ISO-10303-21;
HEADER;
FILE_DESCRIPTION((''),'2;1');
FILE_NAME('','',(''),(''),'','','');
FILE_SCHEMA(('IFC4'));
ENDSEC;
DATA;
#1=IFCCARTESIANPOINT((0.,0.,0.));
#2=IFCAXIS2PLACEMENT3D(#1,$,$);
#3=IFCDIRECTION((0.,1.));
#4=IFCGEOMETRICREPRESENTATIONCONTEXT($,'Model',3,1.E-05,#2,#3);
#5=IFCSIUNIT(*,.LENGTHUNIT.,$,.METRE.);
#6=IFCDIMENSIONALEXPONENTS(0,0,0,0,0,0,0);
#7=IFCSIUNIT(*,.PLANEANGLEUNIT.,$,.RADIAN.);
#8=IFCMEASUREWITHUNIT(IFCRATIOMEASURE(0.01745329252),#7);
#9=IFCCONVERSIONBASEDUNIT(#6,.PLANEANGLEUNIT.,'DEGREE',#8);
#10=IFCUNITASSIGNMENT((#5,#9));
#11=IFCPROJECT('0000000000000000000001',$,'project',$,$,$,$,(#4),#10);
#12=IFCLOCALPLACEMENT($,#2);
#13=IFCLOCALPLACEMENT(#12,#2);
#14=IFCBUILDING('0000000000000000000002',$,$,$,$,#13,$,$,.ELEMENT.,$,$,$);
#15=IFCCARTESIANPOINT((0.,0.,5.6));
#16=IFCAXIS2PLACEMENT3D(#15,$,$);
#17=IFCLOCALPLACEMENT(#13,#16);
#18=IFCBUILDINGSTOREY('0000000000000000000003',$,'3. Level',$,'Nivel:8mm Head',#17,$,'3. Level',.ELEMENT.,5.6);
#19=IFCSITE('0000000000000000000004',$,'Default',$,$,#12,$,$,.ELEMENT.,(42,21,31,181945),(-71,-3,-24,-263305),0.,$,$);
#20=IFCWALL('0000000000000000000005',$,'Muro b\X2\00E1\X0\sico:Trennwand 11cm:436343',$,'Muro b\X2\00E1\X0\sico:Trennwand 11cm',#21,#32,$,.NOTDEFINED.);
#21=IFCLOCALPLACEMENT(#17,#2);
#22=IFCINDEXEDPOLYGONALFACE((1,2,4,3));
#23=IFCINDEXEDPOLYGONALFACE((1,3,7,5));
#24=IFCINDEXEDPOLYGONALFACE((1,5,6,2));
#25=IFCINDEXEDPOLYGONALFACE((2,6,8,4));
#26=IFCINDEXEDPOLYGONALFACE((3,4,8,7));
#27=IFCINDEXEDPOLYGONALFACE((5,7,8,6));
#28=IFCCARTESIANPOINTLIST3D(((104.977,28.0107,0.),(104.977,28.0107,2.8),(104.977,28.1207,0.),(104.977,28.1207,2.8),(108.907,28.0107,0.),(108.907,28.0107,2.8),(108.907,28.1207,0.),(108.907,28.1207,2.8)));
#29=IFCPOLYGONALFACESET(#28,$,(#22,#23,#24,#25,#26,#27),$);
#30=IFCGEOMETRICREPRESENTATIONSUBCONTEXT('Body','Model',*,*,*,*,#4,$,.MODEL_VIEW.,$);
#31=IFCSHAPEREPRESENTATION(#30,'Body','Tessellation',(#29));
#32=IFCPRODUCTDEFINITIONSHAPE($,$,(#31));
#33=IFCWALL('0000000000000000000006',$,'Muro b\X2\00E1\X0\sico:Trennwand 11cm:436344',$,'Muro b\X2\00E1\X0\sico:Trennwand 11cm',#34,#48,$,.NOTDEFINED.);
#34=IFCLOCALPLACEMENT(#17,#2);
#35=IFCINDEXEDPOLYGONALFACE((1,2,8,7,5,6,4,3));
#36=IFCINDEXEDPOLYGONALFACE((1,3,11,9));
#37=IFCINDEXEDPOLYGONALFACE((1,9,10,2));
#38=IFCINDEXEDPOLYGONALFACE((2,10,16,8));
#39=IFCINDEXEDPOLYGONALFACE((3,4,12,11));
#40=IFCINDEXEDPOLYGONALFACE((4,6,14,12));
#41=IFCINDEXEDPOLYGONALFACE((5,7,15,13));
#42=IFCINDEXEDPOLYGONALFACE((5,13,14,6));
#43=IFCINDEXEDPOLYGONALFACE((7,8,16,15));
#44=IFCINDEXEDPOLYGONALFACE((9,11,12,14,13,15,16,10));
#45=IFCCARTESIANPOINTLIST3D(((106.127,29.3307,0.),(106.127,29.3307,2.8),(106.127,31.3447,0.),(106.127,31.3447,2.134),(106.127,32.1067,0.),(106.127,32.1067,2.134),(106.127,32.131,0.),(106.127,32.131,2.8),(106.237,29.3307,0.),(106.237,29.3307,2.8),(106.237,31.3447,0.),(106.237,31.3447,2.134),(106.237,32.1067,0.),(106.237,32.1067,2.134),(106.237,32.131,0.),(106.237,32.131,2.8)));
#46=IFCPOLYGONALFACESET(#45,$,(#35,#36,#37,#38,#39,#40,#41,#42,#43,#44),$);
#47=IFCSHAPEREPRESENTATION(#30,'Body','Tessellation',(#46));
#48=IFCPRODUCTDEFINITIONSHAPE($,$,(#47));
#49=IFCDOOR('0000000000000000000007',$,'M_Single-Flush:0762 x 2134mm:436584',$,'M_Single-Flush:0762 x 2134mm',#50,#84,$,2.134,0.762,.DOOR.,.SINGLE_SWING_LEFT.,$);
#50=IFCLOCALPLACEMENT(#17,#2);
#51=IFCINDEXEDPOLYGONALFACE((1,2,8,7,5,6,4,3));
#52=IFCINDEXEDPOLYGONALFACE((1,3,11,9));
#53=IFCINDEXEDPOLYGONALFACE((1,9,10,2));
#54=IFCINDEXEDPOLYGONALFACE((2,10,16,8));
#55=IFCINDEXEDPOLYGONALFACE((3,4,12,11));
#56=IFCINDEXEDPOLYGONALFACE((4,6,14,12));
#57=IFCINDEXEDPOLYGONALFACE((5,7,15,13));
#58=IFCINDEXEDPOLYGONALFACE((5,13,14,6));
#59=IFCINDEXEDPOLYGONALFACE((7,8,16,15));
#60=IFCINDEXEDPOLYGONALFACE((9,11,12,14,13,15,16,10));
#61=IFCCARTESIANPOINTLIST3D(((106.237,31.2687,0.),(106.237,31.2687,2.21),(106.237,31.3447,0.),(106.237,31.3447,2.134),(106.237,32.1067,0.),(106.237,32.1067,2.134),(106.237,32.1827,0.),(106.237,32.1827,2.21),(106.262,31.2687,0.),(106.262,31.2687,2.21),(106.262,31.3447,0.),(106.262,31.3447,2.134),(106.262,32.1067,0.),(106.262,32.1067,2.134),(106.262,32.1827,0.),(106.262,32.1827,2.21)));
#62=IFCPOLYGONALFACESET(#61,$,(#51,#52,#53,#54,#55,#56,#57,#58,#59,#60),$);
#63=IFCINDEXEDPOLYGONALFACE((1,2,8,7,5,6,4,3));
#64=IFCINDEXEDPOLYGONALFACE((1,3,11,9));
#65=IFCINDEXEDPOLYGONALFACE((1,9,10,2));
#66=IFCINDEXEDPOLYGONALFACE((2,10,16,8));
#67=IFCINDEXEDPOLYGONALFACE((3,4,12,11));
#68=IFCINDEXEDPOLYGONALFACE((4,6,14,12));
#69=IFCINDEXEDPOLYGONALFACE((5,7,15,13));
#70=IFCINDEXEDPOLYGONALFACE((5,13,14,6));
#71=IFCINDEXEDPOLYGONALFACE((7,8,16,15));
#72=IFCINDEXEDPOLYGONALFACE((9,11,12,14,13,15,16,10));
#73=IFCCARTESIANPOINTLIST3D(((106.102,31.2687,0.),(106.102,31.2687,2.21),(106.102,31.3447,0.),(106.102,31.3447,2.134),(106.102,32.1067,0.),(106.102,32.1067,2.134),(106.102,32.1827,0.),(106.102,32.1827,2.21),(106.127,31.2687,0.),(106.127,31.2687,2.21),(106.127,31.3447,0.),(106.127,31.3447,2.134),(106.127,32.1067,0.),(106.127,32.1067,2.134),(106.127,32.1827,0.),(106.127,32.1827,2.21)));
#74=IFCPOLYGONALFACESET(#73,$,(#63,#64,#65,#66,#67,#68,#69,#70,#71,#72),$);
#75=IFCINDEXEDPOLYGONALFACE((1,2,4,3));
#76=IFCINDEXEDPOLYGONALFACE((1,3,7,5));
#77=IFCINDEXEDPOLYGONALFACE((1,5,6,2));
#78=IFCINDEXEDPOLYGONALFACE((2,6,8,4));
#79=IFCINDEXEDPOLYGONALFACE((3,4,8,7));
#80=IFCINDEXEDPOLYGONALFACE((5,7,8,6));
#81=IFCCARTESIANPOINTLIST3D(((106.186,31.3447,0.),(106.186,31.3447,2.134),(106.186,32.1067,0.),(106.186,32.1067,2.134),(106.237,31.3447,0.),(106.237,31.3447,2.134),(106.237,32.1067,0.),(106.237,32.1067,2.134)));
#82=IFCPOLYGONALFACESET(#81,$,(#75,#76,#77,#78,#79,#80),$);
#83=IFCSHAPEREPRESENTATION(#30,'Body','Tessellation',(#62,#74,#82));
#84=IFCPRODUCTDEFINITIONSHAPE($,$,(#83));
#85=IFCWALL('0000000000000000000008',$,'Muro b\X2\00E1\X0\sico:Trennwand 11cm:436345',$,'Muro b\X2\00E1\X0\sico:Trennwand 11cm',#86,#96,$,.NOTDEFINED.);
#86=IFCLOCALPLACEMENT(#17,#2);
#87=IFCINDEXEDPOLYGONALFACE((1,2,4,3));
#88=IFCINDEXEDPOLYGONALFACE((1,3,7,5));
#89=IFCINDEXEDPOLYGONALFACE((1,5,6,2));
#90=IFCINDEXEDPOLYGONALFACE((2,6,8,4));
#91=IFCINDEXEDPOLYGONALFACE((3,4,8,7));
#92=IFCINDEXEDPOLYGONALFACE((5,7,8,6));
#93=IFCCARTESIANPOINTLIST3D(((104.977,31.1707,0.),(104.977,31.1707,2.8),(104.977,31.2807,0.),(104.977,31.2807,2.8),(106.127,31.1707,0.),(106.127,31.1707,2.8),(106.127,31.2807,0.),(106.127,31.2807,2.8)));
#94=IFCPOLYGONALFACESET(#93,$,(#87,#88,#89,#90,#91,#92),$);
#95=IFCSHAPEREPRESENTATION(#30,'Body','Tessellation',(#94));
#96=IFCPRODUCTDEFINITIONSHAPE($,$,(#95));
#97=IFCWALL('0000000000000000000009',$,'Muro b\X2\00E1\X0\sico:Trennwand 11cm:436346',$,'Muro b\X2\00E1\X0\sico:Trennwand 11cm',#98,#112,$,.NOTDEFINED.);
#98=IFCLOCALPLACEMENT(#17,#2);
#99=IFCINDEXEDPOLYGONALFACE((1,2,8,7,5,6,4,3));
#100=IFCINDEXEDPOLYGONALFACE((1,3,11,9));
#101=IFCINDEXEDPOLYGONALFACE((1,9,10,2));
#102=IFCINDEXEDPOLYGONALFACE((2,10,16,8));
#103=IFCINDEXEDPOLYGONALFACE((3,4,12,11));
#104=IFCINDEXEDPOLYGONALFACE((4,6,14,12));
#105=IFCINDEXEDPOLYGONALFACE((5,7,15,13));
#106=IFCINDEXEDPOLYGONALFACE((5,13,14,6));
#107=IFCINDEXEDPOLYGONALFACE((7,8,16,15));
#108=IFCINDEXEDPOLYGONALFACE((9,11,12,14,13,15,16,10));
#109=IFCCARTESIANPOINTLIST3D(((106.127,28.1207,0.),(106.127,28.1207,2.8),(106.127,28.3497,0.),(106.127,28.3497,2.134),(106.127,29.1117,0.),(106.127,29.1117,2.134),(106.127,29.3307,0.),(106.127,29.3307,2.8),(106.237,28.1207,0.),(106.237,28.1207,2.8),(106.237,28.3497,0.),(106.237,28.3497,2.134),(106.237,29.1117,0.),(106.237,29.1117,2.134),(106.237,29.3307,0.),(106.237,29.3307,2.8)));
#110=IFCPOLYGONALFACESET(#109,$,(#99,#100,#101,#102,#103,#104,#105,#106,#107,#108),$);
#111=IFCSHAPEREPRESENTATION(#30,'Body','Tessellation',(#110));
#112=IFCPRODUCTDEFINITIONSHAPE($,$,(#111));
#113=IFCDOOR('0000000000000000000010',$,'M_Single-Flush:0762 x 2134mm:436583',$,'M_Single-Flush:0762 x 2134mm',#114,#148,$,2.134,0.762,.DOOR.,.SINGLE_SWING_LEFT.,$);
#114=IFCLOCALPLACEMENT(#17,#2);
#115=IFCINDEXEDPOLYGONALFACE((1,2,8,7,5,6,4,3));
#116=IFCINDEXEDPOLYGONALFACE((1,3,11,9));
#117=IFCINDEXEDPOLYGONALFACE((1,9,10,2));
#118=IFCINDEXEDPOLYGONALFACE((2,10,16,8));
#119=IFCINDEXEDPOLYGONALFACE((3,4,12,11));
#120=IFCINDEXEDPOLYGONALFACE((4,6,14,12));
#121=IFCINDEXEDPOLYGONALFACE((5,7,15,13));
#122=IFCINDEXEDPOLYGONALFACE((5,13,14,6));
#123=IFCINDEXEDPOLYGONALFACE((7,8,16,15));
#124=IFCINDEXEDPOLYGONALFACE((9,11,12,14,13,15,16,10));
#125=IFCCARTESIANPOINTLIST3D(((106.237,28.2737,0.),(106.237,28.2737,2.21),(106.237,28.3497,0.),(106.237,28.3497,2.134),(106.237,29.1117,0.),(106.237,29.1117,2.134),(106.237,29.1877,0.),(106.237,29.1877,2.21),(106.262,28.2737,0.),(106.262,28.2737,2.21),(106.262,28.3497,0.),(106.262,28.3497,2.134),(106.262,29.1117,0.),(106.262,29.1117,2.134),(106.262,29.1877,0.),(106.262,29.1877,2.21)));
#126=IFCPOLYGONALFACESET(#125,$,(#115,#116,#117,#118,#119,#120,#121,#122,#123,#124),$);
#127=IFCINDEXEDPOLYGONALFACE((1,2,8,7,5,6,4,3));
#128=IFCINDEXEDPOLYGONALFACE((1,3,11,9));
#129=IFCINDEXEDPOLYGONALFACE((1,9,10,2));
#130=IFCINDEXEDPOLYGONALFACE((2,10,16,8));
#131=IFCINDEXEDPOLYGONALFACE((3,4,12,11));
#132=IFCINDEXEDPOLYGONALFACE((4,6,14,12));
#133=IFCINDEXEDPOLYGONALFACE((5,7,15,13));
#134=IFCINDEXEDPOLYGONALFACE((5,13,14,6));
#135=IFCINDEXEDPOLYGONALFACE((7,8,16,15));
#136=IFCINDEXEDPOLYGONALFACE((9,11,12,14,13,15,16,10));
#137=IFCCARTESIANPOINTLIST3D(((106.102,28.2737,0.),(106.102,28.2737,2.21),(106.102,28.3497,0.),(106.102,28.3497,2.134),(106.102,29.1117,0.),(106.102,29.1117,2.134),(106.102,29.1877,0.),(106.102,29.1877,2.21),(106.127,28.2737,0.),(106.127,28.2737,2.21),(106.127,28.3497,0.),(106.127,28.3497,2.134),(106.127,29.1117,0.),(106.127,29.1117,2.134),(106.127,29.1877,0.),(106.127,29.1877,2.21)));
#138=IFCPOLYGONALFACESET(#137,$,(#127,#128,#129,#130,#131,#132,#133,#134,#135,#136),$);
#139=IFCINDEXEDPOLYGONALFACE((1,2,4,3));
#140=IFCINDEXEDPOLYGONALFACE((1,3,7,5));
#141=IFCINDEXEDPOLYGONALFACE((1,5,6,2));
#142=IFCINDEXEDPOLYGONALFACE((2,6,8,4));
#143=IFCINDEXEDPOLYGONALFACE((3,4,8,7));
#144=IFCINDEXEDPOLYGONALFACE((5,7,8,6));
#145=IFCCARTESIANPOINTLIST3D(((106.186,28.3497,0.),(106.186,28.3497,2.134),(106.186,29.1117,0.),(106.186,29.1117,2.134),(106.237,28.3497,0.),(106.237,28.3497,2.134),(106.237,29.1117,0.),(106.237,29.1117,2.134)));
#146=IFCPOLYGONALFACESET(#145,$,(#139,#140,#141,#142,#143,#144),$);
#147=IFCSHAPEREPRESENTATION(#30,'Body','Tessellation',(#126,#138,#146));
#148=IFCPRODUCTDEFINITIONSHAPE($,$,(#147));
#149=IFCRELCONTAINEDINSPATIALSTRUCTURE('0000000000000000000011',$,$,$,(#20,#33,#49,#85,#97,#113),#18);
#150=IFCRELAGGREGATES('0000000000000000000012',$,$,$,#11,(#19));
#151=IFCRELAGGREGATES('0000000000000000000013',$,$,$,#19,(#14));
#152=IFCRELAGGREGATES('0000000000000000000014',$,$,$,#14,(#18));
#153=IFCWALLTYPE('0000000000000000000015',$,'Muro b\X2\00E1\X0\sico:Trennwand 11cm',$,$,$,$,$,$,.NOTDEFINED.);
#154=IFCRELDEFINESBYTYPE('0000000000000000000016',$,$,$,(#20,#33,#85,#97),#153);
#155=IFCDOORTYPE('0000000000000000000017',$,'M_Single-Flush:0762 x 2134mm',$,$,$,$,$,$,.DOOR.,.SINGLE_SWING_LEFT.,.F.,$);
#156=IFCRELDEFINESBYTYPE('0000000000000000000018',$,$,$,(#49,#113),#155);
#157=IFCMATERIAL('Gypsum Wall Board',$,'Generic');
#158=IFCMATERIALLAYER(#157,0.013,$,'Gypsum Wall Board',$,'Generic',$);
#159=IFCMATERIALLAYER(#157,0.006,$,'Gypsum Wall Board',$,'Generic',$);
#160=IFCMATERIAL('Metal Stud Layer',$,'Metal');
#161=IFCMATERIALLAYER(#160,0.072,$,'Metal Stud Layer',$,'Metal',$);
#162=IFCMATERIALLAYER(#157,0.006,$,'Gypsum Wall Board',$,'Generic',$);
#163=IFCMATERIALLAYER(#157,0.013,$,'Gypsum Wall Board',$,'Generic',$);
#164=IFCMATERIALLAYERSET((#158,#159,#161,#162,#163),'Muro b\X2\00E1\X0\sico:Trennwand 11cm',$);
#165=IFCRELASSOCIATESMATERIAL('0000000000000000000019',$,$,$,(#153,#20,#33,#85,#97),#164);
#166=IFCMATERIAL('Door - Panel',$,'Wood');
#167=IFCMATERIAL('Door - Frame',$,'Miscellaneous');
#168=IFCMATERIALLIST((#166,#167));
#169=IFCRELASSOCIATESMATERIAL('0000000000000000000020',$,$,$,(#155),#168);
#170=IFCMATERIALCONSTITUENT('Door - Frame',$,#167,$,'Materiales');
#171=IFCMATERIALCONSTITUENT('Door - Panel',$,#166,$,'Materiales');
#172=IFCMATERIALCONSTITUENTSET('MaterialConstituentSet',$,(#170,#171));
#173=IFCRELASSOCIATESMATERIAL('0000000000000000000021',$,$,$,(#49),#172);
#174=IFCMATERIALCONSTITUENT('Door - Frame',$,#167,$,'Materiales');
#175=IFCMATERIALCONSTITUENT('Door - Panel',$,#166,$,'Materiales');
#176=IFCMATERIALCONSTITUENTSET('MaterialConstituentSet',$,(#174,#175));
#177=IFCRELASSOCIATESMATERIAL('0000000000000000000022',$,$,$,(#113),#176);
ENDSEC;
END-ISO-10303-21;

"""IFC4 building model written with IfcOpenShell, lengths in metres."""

from ifc_helpers import new_model, entity, si_unit, converted_unit, direction, frame, frame_2d, origin, origin_2d_with_axis, place, context, subcontext, project, spatial, polyline, rectangle, outline, extrude, source, transform, mapped, material, material_list, layer, layer_set, layer_usage, constituent, constituent_set, type_object, type_shapes, element, fill, save


model = new_model("IFC4")

# Units and contexts
model_context = context("Model", 3, precision=1e-05, world=origin(), true_north=direction((0.0, 1.0)))
body_context = subcontext(model_context, "Body", "Model", "MODEL_VIEW")
ifc_project = project(units=[si_unit("LENGTHUNIT", "METRE"), converted_unit("PLANEANGLEUNIT", "DEGREE", entity("IfcRatioMeasure", 0.01745329252), si_unit("PLANEANGLEUNIT", "RADIAN"), dimensions=[0, 0, 0, 0, 0, 0, 0])], contexts=[model_context])

# Site, building, storey
site_placement = place(None, origin())
site = spatial("IfcSite", under=ifc_project, at=site_placement, Name="Default", CompositionType="ELEMENT", RefLatitude=(42, 21, 31, 181945), RefLongitude=(-71, -3, -24, -263305), RefElevation=0.0)
building_placement = place(site_placement, origin())
building = spatial("IfcBuilding", under=site, at=building_placement, CompositionType="ELEMENT")
storey_placement = place(building_placement, frame((0.0, 0.0, 5.6)))
storey = spatial("IfcBuildingStorey", under=building, at=storey_placement, Name="3. Level", ObjectType="Nivel:8mm Head", LongName="3. Level", CompositionType="ELEMENT", Elevation=5.6)

# Shared definitions
ifc_material_1 = material(Name="Gypsum Wall Board", Category="Generic")
ifc_layer_1 = layer(ifc_material_1, 0.013, Name="Gypsum Wall Board", Category="Generic")
ifc_layer_2 = layer(ifc_material_1, 0.006, Name="Gypsum Wall Board", Category="Generic")
ifc_material_2 = material(Name="Metal Stud Layer", Category="Metal")
ifc_layer_3 = layer(ifc_material_2, 0.072, Name="Metal Stud Layer", Category="Metal")
ifc_layer_4 = layer(ifc_material_1, 0.006, Name="Gypsum Wall Board", Category="Generic")
ifc_layer_5 = layer(ifc_material_1, 0.013, Name="Gypsum Wall Board", Category="Generic")
ifc_layer_set_1 = layer_set([ifc_layer_1, ifc_layer_2, ifc_layer_3, ifc_layer_4, ifc_layer_5], Name="Muro básico:Trennwand 11cm")
wall_type_1 = type_object("IfcWallType", Name="Muro básico:Trennwand 11cm", PredefinedType="NOTDEFINED", material=ifc_layer_set_1)
ifc_material_3 = material(Name="Door - Frame", Category="Miscellaneous")

# Shared definitions
ifc_material_4 = material(Name="Door - Panel", Category="Wood")
ifc_material_list_1 = material_list([ifc_material_4, ifc_material_3])
door_type_1 = type_object("IfcDoorType", Name="M_Single-Flush:0762 x 2134mm", OperationType="SINGLE_SWING_LEFT", ParameterTakesPrecedence=False, PredefinedType="DOOR", material=ifc_material_list_1)
shared_shape_1 = source(origin(), body_context, "Body", "SweptSolid", [
    extrude(outline(polyline([(-0.457, -1.124), (0.457, -1.124), (0.457, 1.086), (0.381, 1.086), (0.381, -1.048), (-0.381, -1.048), (-0.381, 1.086), (-0.457, 1.086), (-0.457, -1.124)])), frame((0.381, 0.135, 1.086), z_axis=(0.0, -1.0, 0.0), x_axis=(-1.0, 0.0, 0.0)), (0.0, 0.0, 1.0), 0.025),
    extrude(outline(polyline([(-1.124, -0.457), (1.086, -0.457), (1.086, -0.381), (-1.048, -0.381), (-1.048, 0.381), (1.086, 0.381), (1.086, 0.457), (-1.124, 0.457), (-1.124, -0.457)])), frame((0.381, 0.0, 1.086), z_axis=(0.0, -1.0, 0.0), x_axis=(0.0, 0.0, -1.0)), (0.0, 0.0, 1.0), 0.025),
    extrude(rectangle(XDim=0.762, YDim=0.051, at=origin_2d_with_axis()), frame((0.381, 0.0845, 0.0)), (0.0, 0.0, 1.0), 2.134),
])
type_shapes(door_type_1, [shared_shape_1])

# Wall
ifc_layer_usage_1 = layer_usage(ifc_layer_set_1, "AXIS2", "NEGATIVE", 0.055)
wall_1_placement = place(storey_placement, frame((104.977, 28.0657, 0.0)))
element("IfcWall", 1, at=wall_1_placement, inside=storey, type_object=wall_type_1, material=ifc_layer_usage_1, Name="Muro básico:Trennwand 11cm:436343", ObjectType="Muro básico:Trennwand 11cm", PredefinedType="NOTDEFINED", context=body_context, shape_type="SweptSolid", body=[
    extrude(rectangle(XDim=3.93, YDim=0.11, at=frame_2d((1.965, 0.0), x_axis=(-1.0, 0.0))), origin(), (0.0, 0.0, 1.0), 2.8),
])

# Wall, opening, door
ifc_layer_usage_2 = layer_usage(ifc_layer_set_1, "AXIS2", "NEGATIVE", 0.055)
wall_2_placement = place(storey_placement, frame((106.182, 32.131, 0.0), z_axis=(0.0, 0.0, 1.0), x_axis=(0.0, -1.0, 0.0)))
wall_2 = element("IfcWall", 2, at=wall_2_placement, inside=storey, type_object=wall_type_1, material=ifc_layer_usage_2, Name="Muro básico:Trennwand 11cm:436344", ObjectType="Muro básico:Trennwand 11cm", PredefinedType="NOTDEFINED", context=body_context, shape_type="SweptSolid", body=[
    extrude(rectangle(XDim=2.8003, YDim=0.11, at=frame_2d((1.4002, 0.0), x_axis=(-1.0, 0.0))), origin(), (0.0, 0.0, 1.0), 2.8),
])
opening_1_placement = place(wall_2_placement, frame((0.0243, -0.055, 0.0)))
opening_1 = element("IfcOpeningElement", 3, at=opening_1_placement, cuts=wall_2, ObjectType="Opening", PredefinedType="OPENING", context=body_context, shape_type="SweptSolid", body=[
    extrude(rectangle(XDim=0.762, YDim=2.134, at=frame_2d((1.067, 0.381), x_axis=(0.0, -1.0))), frame((0.0, 0.0, 0.0), z_axis=(0.0, 1.0, 0.0), x_axis=(0.0, 0.0, 1.0)), (0.0, 0.0, 1.0), 0.11),
])
ifc_constituent_1 = constituent(ifc_material_3, Name="Door - Frame", Category="Materiales")
ifc_constituent_2 = constituent(ifc_material_4, Name="Door - Panel", Category="Materiales")
ifc_constituent_set_1 = constituent_set(constituents=[ifc_constituent_1, ifc_constituent_2], Name="MaterialConstituentSet")
door_1_placement = place(opening_1_placement, origin())
door_1 = element("IfcDoor", 4, at=door_1_placement, inside=storey, type_object=door_type_1, material=ifc_constituent_set_1, Name="M_Single-Flush:0762 x 2134mm:436584", ObjectType="M_Single-Flush:0762 x 2134mm", OperationType="SINGLE_SWING_LEFT", OverallHeight=2.134, OverallWidth=0.762, PredefinedType="DOOR", context=body_context, shape_type="MappedRepresentation", body=[
    mapped(shared_shape_1, transform((0.0, 0.0, 0.0), scale=1.0)),
])
fill(opening_1, door_1)

# Wall
ifc_layer_usage_3 = layer_usage(ifc_layer_set_1, "AXIS2", "NEGATIVE", 0.055)
wall_3_placement = place(storey_placement, frame((106.127, 31.2257, 0.0), z_axis=(0.0, 0.0, 1.0), x_axis=(-1.0, 0.0, 0.0)))
element("IfcWall", 5, at=wall_3_placement, inside=storey, type_object=wall_type_1, material=ifc_layer_usage_3, Name="Muro básico:Trennwand 11cm:436345", ObjectType="Muro básico:Trennwand 11cm", PredefinedType="NOTDEFINED", context=body_context, shape_type="SweptSolid", body=[
    extrude(rectangle(XDim=1.15, YDim=0.11, at=frame_2d((0.575, 0.0), x_axis=(-1.0, 0.0))), origin(), (0.0, 0.0, 1.0), 2.8),
])

# Wall, opening, door
ifc_layer_usage_4 = layer_usage(ifc_layer_set_1, "AXIS2", "NEGATIVE", 0.055)
wall_4_placement = place(storey_placement, frame((106.182, 28.1207, 0.0), z_axis=(0.0, 0.0, 1.0), x_axis=(0.0, 1.0, 0.0)))
wall_4 = element("IfcWall", 6, at=wall_4_placement, inside=storey, type_object=wall_type_1, material=ifc_layer_usage_4, Name="Muro básico:Trennwand 11cm:436346", ObjectType="Muro básico:Trennwand 11cm", PredefinedType="NOTDEFINED", context=body_context, shape_type="SweptSolid", body=[
    extrude(rectangle(XDim=1.21, YDim=0.11, at=frame_2d((0.605, 0.0), x_axis=(-1.0, 0.0))), origin(), (0.0, 0.0, 1.0), 2.8),
])
opening_2_placement = place(wall_4_placement, frame((0.991, 0.055, 0.0)))
opening_2 = element("IfcOpeningElement", 7, at=opening_2_placement, cuts=wall_4, ObjectType="Opening", PredefinedType="OPENING", context=body_context, shape_type="SweptSolid", body=[
    extrude(rectangle(XDim=0.762, YDim=2.134, at=frame_2d((1.067, 0.381), x_axis=(0.0, -1.0))), frame((0.0, 0.0, 0.0), z_axis=(0.0, -1.0, 0.0), x_axis=(0.0, 0.0, 1.0)), (0.0, 0.0, 1.0), 0.11),
])
ifc_constituent_3 = constituent(ifc_material_3, Name="Door - Frame", Category="Materiales")
ifc_constituent_4 = constituent(ifc_material_4, Name="Door - Panel", Category="Materiales")
ifc_constituent_set_2 = constituent_set(constituents=[ifc_constituent_3, ifc_constituent_4], Name="MaterialConstituentSet")
door_2_placement = place(opening_2_placement, frame((0.0, 0.0, 0.0), z_axis=(0.0, 0.0, 1.0), x_axis=(-1.0, 0.0, 0.0)))
door_2 = element("IfcDoor", 8, at=door_2_placement, inside=storey, type_object=door_type_1, material=ifc_constituent_set_2, Name="M_Single-Flush:0762 x 2134mm:436583", ObjectType="M_Single-Flush:0762 x 2134mm", OperationType="SINGLE_SWING_LEFT", OverallHeight=2.134, OverallWidth=0.762, PredefinedType="DOOR", context=body_context, shape_type="MappedRepresentation", body=[
    mapped(shared_shape_1, transform((0.0, 0.0, 0.0), scale=1.0)),
])
fill(opening_2, door_2)

save(model, "model.ifc")
